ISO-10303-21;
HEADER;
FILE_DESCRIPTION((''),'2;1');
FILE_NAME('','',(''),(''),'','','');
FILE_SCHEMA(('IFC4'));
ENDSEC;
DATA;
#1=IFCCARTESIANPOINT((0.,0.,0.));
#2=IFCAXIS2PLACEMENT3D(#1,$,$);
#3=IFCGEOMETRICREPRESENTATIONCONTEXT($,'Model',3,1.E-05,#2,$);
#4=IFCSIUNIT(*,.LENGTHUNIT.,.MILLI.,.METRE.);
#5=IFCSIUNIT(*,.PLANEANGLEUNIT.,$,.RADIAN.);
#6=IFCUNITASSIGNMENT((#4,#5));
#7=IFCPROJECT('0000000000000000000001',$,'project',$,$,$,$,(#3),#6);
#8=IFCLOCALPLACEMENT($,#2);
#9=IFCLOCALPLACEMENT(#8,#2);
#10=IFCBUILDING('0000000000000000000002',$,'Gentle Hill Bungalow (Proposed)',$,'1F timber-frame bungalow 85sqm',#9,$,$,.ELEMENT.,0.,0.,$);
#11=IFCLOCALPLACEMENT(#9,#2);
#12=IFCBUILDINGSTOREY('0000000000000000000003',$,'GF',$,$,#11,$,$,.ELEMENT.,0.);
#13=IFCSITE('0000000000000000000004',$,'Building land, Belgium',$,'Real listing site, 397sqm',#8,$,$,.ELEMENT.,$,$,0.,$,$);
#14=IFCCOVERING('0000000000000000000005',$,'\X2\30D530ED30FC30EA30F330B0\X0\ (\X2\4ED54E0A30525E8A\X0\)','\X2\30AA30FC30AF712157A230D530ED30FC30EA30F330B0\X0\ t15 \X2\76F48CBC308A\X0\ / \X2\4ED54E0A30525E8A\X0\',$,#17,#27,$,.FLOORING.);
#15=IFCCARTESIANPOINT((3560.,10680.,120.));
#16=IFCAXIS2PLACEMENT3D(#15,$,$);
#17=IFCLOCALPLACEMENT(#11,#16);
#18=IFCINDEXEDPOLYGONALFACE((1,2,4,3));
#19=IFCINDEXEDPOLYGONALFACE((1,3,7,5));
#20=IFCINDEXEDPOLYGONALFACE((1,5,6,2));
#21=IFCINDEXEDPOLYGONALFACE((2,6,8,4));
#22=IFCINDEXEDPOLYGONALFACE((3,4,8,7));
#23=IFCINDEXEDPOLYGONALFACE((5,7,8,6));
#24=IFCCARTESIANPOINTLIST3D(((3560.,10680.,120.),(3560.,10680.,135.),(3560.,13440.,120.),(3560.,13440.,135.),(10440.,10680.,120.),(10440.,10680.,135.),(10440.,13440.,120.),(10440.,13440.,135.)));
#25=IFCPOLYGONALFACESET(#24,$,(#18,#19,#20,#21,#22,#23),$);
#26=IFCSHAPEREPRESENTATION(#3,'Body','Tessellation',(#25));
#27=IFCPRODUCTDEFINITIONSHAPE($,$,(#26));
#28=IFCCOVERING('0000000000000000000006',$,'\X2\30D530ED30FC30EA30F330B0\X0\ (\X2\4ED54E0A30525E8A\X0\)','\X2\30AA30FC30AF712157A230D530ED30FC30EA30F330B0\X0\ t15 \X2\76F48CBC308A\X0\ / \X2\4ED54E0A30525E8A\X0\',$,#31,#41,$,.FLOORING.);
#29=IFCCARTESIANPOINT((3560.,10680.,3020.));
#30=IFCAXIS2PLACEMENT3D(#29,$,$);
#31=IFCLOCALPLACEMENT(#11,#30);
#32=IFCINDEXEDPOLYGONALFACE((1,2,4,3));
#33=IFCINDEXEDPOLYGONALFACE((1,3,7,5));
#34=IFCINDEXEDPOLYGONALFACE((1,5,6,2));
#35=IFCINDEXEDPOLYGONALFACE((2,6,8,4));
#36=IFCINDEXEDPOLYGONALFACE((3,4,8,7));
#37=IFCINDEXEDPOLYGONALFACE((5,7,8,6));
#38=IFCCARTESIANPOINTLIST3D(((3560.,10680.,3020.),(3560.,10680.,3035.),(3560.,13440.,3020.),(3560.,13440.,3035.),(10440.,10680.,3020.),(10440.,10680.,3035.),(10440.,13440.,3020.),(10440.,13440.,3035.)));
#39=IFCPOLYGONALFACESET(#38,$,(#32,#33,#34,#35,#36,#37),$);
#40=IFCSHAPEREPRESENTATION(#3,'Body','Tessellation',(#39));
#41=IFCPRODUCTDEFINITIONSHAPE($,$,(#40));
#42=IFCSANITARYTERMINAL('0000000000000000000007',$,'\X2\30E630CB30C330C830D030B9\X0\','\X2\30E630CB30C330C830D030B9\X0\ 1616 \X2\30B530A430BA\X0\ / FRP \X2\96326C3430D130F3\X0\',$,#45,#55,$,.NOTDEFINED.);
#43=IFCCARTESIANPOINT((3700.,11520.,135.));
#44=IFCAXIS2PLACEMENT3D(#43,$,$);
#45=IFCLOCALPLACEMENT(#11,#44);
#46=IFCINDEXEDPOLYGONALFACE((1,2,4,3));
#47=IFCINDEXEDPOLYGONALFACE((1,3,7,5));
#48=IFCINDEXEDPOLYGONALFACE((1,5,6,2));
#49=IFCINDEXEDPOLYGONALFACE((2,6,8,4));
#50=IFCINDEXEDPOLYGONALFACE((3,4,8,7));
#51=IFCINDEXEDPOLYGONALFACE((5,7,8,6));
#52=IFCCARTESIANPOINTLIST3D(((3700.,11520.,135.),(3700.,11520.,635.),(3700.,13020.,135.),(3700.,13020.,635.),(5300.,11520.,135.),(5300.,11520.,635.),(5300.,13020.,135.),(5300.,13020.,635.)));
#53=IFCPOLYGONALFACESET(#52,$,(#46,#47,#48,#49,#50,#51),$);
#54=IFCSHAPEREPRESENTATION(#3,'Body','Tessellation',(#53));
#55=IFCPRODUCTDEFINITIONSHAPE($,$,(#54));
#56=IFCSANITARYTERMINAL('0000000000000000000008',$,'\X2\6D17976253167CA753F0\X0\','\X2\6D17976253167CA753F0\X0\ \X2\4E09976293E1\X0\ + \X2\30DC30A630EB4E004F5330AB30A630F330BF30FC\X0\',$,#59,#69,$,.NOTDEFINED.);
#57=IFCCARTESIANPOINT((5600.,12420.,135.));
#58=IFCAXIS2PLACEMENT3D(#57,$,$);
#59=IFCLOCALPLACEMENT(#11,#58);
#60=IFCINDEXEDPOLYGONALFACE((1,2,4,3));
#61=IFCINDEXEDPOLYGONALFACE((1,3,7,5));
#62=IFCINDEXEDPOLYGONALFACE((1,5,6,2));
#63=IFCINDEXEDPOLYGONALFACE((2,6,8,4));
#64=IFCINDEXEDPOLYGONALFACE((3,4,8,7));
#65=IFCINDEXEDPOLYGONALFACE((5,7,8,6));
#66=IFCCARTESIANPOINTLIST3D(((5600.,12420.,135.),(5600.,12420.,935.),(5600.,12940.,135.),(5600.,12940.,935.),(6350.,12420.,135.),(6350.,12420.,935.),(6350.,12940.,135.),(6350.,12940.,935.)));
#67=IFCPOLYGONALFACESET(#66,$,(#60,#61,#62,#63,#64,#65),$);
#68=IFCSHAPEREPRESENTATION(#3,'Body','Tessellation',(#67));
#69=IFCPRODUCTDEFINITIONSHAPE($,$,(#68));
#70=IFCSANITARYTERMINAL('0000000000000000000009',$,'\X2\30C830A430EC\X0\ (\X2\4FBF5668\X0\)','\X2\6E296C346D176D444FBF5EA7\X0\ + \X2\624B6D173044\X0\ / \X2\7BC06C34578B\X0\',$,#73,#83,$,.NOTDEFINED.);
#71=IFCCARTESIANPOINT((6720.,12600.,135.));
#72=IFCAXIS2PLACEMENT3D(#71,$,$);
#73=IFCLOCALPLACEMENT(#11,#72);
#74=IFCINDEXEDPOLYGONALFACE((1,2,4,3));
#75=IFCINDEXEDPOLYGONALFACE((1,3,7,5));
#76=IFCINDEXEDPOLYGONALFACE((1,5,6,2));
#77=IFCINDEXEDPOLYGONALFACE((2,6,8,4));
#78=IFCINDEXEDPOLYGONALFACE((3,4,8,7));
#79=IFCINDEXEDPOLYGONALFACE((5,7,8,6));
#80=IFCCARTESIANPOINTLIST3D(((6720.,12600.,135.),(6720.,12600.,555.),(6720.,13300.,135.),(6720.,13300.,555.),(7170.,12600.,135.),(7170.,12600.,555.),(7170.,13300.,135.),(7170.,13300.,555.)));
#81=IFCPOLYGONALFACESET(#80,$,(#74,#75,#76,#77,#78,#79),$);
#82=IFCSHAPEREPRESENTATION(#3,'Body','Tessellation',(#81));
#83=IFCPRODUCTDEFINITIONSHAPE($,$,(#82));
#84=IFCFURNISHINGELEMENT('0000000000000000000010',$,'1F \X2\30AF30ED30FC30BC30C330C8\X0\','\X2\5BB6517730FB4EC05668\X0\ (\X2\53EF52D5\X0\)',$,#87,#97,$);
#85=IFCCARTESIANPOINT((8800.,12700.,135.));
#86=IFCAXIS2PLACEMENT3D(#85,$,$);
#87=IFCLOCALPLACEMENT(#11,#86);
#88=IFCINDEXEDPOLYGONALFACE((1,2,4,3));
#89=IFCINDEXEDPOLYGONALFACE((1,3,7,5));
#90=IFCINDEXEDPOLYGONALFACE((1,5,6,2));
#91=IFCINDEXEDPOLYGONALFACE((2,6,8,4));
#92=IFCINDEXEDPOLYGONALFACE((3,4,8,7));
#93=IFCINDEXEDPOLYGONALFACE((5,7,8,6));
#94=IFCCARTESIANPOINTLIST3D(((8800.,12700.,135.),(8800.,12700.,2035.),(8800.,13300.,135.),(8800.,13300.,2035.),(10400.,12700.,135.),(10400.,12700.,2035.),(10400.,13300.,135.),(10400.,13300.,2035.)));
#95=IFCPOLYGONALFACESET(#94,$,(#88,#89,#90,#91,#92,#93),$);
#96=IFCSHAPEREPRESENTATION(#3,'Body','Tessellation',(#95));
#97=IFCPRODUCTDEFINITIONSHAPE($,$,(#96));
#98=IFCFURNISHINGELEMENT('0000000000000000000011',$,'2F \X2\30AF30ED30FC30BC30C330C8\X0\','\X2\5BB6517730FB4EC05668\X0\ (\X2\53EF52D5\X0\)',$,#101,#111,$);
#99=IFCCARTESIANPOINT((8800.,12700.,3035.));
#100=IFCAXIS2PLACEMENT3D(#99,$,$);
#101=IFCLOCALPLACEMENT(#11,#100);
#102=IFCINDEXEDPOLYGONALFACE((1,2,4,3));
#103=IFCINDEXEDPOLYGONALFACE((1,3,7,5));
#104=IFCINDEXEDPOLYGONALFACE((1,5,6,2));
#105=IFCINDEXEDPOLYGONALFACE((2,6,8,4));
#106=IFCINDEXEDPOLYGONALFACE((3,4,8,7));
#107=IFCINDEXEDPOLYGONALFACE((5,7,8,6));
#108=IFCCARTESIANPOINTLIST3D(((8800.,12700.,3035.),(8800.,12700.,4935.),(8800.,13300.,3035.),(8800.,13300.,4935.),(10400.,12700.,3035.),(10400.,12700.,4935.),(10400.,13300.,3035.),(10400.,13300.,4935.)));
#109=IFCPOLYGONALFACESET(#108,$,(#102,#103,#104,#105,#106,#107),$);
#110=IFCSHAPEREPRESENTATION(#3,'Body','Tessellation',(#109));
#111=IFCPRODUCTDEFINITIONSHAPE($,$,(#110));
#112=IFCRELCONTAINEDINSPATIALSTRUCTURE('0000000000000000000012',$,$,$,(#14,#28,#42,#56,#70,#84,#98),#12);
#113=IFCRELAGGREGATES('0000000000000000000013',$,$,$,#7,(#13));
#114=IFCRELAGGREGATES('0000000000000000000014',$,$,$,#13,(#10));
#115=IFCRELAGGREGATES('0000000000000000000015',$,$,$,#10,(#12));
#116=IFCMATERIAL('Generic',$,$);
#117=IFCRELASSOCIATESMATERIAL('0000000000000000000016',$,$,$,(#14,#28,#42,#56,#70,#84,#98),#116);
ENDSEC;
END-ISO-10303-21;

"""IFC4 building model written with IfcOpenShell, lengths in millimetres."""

from ifc_helpers import new_model, si_unit, frame, frame_2d, origin, place, context, project, spatial, rectangle, extrude, material, element, save


model = new_model("IFC4")

# Units and contexts
model_context = context("Model", 3, precision=1e-05, world=origin())
ifc_project = project(units=[si_unit("LENGTHUNIT", "METRE", prefix="MILLI"), si_unit("PLANEANGLEUNIT", "RADIAN")], contexts=[model_context])

# Site, building, storey
site_placement = place(None, origin())
site = spatial("IfcSite", under=ifc_project, at=site_placement, Name="Building land, Belgium", ObjectType="Real listing site, 397sqm", CompositionType="ELEMENT", RefElevation=0.0)
building_placement = place(site_placement, origin())
building = spatial("IfcBuilding", under=site, at=building_placement, Name="Gentle Hill Bungalow (Proposed)", ObjectType="1F timber-frame bungalow 85sqm", CompositionType="ELEMENT", ElevationOfRefHeight=0.0, ElevationOfTerrain=0.0)
storey_placement = place(building_placement, origin())
storey = spatial("IfcBuildingStorey", under=building, at=storey_placement, Name="GF", CompositionType="ELEMENT", Elevation=0.0)

# Coverings
ifc_material_1 = material(Name="Generic")
covering_1_placement = place(storey_placement, frame((3560.0, 10680.0, 120.0)))
element("IfcCovering", 1, at=covering_1_placement, inside=storey, material=ifc_material_1, Name="フローリング (仕上げ床)", Description="オーク無垢フローリング t15 直貼り / 仕上げ床", PredefinedType="FLOORING", context=model_context, shape_type="SweptSolid", body=[
    extrude(rectangle(XDim=6880.0, YDim=2760.0, at=frame_2d((3440.0, 1380.0))), frame((3560.0, 10680.0, 120.0)), (0.0, 0.0, 1.0), 15.0),
])
covering_2_placement = place(storey_placement, frame((3560.0, 10680.0, 3020.0)))
element("IfcCovering", 2, at=covering_2_placement, inside=storey, material=ifc_material_1, Name="フローリング (仕上げ床)", Description="オーク無垢フローリング t15 直貼り / 仕上げ床", PredefinedType="FLOORING", context=model_context, shape_type="SweptSolid", body=[
    extrude(rectangle(XDim=6880.0, YDim=2760.0, at=frame_2d((3440.0, 1380.0))), frame((3560.0, 10680.0, 3020.0)), (0.0, 0.0, 1.0), 15.0),
])

# Sanitary terminals
sanitary_terminal_1_placement = place(storey_placement, frame((3700.0, 11520.0, 135.0)))
element("IfcSanitaryTerminal", 3, at=sanitary_terminal_1_placement, inside=storey, material=ifc_material_1, Name="ユニットバス", Description="ユニットバス 1616 サイズ / FRP 防水パン", PredefinedType="NOTDEFINED", context=model_context, shape_type="SweptSolid", body=[
    extrude(rectangle(XDim=1600.0, YDim=1500.0, at=frame_2d((800.0, 750.0))), frame((3700.0, 11520.0, 135.0)), (0.0, 0.0, 1.0), 500.0),
])
sanitary_terminal_2_placement = place(storey_placement, frame((5600.0, 12420.0, 135.0)))
element("IfcSanitaryTerminal", 4, at=sanitary_terminal_2_placement, inside=storey, material=ifc_material_1, Name="洗面化粧台", Description="洗面化粧台 三面鏡 + ボウル一体カウンター", PredefinedType="NOTDEFINED", context=model_context, shape_type="SweptSolid", body=[
    extrude(rectangle(XDim=750.0, YDim=520.0, at=frame_2d((375.0, 260.0))), frame((5600.0, 12420.0, 135.0)), (0.0, 0.0, 1.0), 800.0),
])
sanitary_terminal_3_placement = place(storey_placement, frame((6720.0, 12600.0, 135.0)))
element("IfcSanitaryTerminal", 5, at=sanitary_terminal_3_placement, inside=storey, material=ifc_material_1, Name="トイレ (便器)", Description="温水洗浄便座 + 手洗い / 節水型", PredefinedType="NOTDEFINED", context=model_context, shape_type="SweptSolid", body=[
    extrude(rectangle(XDim=450.0, YDim=700.0, at=frame_2d((225.0, 350.0))), frame((6720.0, 12600.0, 135.0)), (0.0, 0.0, 1.0), 420.0),
])

# Furnishing elements
furnishing_1_placement = place(storey_placement, frame((8800.0, 12700.0, 135.0)))
element("IfcFurnishingElement", 6, at=furnishing_1_placement, inside=storey, material=ifc_material_1, Name="1F クローゼット", Description="家具・什器 (可動)", context=model_context, shape_type="SweptSolid", body=[
    extrude(rectangle(XDim=1600.0, YDim=600.0, at=frame_2d((800.0, 300.0))), frame((8800.0, 12700.0, 135.0)), (0.0, 0.0, 1.0), 1900.0),
])
furnishing_2_placement = place(storey_placement, frame((8800.0, 12700.0, 3035.0)))
element("IfcFurnishingElement", 7, at=furnishing_2_placement, inside=storey, material=ifc_material_1, Name="2F クローゼット", Description="家具・什器 (可動)", context=model_context, shape_type="SweptSolid", body=[
    extrude(rectangle(XDim=1600.0, YDim=600.0, at=frame_2d((800.0, 300.0))), frame((8800.0, 12700.0, 3035.0)), (0.0, 0.0, 1.0), 1900.0),
])

save(model, "model.ifc")
